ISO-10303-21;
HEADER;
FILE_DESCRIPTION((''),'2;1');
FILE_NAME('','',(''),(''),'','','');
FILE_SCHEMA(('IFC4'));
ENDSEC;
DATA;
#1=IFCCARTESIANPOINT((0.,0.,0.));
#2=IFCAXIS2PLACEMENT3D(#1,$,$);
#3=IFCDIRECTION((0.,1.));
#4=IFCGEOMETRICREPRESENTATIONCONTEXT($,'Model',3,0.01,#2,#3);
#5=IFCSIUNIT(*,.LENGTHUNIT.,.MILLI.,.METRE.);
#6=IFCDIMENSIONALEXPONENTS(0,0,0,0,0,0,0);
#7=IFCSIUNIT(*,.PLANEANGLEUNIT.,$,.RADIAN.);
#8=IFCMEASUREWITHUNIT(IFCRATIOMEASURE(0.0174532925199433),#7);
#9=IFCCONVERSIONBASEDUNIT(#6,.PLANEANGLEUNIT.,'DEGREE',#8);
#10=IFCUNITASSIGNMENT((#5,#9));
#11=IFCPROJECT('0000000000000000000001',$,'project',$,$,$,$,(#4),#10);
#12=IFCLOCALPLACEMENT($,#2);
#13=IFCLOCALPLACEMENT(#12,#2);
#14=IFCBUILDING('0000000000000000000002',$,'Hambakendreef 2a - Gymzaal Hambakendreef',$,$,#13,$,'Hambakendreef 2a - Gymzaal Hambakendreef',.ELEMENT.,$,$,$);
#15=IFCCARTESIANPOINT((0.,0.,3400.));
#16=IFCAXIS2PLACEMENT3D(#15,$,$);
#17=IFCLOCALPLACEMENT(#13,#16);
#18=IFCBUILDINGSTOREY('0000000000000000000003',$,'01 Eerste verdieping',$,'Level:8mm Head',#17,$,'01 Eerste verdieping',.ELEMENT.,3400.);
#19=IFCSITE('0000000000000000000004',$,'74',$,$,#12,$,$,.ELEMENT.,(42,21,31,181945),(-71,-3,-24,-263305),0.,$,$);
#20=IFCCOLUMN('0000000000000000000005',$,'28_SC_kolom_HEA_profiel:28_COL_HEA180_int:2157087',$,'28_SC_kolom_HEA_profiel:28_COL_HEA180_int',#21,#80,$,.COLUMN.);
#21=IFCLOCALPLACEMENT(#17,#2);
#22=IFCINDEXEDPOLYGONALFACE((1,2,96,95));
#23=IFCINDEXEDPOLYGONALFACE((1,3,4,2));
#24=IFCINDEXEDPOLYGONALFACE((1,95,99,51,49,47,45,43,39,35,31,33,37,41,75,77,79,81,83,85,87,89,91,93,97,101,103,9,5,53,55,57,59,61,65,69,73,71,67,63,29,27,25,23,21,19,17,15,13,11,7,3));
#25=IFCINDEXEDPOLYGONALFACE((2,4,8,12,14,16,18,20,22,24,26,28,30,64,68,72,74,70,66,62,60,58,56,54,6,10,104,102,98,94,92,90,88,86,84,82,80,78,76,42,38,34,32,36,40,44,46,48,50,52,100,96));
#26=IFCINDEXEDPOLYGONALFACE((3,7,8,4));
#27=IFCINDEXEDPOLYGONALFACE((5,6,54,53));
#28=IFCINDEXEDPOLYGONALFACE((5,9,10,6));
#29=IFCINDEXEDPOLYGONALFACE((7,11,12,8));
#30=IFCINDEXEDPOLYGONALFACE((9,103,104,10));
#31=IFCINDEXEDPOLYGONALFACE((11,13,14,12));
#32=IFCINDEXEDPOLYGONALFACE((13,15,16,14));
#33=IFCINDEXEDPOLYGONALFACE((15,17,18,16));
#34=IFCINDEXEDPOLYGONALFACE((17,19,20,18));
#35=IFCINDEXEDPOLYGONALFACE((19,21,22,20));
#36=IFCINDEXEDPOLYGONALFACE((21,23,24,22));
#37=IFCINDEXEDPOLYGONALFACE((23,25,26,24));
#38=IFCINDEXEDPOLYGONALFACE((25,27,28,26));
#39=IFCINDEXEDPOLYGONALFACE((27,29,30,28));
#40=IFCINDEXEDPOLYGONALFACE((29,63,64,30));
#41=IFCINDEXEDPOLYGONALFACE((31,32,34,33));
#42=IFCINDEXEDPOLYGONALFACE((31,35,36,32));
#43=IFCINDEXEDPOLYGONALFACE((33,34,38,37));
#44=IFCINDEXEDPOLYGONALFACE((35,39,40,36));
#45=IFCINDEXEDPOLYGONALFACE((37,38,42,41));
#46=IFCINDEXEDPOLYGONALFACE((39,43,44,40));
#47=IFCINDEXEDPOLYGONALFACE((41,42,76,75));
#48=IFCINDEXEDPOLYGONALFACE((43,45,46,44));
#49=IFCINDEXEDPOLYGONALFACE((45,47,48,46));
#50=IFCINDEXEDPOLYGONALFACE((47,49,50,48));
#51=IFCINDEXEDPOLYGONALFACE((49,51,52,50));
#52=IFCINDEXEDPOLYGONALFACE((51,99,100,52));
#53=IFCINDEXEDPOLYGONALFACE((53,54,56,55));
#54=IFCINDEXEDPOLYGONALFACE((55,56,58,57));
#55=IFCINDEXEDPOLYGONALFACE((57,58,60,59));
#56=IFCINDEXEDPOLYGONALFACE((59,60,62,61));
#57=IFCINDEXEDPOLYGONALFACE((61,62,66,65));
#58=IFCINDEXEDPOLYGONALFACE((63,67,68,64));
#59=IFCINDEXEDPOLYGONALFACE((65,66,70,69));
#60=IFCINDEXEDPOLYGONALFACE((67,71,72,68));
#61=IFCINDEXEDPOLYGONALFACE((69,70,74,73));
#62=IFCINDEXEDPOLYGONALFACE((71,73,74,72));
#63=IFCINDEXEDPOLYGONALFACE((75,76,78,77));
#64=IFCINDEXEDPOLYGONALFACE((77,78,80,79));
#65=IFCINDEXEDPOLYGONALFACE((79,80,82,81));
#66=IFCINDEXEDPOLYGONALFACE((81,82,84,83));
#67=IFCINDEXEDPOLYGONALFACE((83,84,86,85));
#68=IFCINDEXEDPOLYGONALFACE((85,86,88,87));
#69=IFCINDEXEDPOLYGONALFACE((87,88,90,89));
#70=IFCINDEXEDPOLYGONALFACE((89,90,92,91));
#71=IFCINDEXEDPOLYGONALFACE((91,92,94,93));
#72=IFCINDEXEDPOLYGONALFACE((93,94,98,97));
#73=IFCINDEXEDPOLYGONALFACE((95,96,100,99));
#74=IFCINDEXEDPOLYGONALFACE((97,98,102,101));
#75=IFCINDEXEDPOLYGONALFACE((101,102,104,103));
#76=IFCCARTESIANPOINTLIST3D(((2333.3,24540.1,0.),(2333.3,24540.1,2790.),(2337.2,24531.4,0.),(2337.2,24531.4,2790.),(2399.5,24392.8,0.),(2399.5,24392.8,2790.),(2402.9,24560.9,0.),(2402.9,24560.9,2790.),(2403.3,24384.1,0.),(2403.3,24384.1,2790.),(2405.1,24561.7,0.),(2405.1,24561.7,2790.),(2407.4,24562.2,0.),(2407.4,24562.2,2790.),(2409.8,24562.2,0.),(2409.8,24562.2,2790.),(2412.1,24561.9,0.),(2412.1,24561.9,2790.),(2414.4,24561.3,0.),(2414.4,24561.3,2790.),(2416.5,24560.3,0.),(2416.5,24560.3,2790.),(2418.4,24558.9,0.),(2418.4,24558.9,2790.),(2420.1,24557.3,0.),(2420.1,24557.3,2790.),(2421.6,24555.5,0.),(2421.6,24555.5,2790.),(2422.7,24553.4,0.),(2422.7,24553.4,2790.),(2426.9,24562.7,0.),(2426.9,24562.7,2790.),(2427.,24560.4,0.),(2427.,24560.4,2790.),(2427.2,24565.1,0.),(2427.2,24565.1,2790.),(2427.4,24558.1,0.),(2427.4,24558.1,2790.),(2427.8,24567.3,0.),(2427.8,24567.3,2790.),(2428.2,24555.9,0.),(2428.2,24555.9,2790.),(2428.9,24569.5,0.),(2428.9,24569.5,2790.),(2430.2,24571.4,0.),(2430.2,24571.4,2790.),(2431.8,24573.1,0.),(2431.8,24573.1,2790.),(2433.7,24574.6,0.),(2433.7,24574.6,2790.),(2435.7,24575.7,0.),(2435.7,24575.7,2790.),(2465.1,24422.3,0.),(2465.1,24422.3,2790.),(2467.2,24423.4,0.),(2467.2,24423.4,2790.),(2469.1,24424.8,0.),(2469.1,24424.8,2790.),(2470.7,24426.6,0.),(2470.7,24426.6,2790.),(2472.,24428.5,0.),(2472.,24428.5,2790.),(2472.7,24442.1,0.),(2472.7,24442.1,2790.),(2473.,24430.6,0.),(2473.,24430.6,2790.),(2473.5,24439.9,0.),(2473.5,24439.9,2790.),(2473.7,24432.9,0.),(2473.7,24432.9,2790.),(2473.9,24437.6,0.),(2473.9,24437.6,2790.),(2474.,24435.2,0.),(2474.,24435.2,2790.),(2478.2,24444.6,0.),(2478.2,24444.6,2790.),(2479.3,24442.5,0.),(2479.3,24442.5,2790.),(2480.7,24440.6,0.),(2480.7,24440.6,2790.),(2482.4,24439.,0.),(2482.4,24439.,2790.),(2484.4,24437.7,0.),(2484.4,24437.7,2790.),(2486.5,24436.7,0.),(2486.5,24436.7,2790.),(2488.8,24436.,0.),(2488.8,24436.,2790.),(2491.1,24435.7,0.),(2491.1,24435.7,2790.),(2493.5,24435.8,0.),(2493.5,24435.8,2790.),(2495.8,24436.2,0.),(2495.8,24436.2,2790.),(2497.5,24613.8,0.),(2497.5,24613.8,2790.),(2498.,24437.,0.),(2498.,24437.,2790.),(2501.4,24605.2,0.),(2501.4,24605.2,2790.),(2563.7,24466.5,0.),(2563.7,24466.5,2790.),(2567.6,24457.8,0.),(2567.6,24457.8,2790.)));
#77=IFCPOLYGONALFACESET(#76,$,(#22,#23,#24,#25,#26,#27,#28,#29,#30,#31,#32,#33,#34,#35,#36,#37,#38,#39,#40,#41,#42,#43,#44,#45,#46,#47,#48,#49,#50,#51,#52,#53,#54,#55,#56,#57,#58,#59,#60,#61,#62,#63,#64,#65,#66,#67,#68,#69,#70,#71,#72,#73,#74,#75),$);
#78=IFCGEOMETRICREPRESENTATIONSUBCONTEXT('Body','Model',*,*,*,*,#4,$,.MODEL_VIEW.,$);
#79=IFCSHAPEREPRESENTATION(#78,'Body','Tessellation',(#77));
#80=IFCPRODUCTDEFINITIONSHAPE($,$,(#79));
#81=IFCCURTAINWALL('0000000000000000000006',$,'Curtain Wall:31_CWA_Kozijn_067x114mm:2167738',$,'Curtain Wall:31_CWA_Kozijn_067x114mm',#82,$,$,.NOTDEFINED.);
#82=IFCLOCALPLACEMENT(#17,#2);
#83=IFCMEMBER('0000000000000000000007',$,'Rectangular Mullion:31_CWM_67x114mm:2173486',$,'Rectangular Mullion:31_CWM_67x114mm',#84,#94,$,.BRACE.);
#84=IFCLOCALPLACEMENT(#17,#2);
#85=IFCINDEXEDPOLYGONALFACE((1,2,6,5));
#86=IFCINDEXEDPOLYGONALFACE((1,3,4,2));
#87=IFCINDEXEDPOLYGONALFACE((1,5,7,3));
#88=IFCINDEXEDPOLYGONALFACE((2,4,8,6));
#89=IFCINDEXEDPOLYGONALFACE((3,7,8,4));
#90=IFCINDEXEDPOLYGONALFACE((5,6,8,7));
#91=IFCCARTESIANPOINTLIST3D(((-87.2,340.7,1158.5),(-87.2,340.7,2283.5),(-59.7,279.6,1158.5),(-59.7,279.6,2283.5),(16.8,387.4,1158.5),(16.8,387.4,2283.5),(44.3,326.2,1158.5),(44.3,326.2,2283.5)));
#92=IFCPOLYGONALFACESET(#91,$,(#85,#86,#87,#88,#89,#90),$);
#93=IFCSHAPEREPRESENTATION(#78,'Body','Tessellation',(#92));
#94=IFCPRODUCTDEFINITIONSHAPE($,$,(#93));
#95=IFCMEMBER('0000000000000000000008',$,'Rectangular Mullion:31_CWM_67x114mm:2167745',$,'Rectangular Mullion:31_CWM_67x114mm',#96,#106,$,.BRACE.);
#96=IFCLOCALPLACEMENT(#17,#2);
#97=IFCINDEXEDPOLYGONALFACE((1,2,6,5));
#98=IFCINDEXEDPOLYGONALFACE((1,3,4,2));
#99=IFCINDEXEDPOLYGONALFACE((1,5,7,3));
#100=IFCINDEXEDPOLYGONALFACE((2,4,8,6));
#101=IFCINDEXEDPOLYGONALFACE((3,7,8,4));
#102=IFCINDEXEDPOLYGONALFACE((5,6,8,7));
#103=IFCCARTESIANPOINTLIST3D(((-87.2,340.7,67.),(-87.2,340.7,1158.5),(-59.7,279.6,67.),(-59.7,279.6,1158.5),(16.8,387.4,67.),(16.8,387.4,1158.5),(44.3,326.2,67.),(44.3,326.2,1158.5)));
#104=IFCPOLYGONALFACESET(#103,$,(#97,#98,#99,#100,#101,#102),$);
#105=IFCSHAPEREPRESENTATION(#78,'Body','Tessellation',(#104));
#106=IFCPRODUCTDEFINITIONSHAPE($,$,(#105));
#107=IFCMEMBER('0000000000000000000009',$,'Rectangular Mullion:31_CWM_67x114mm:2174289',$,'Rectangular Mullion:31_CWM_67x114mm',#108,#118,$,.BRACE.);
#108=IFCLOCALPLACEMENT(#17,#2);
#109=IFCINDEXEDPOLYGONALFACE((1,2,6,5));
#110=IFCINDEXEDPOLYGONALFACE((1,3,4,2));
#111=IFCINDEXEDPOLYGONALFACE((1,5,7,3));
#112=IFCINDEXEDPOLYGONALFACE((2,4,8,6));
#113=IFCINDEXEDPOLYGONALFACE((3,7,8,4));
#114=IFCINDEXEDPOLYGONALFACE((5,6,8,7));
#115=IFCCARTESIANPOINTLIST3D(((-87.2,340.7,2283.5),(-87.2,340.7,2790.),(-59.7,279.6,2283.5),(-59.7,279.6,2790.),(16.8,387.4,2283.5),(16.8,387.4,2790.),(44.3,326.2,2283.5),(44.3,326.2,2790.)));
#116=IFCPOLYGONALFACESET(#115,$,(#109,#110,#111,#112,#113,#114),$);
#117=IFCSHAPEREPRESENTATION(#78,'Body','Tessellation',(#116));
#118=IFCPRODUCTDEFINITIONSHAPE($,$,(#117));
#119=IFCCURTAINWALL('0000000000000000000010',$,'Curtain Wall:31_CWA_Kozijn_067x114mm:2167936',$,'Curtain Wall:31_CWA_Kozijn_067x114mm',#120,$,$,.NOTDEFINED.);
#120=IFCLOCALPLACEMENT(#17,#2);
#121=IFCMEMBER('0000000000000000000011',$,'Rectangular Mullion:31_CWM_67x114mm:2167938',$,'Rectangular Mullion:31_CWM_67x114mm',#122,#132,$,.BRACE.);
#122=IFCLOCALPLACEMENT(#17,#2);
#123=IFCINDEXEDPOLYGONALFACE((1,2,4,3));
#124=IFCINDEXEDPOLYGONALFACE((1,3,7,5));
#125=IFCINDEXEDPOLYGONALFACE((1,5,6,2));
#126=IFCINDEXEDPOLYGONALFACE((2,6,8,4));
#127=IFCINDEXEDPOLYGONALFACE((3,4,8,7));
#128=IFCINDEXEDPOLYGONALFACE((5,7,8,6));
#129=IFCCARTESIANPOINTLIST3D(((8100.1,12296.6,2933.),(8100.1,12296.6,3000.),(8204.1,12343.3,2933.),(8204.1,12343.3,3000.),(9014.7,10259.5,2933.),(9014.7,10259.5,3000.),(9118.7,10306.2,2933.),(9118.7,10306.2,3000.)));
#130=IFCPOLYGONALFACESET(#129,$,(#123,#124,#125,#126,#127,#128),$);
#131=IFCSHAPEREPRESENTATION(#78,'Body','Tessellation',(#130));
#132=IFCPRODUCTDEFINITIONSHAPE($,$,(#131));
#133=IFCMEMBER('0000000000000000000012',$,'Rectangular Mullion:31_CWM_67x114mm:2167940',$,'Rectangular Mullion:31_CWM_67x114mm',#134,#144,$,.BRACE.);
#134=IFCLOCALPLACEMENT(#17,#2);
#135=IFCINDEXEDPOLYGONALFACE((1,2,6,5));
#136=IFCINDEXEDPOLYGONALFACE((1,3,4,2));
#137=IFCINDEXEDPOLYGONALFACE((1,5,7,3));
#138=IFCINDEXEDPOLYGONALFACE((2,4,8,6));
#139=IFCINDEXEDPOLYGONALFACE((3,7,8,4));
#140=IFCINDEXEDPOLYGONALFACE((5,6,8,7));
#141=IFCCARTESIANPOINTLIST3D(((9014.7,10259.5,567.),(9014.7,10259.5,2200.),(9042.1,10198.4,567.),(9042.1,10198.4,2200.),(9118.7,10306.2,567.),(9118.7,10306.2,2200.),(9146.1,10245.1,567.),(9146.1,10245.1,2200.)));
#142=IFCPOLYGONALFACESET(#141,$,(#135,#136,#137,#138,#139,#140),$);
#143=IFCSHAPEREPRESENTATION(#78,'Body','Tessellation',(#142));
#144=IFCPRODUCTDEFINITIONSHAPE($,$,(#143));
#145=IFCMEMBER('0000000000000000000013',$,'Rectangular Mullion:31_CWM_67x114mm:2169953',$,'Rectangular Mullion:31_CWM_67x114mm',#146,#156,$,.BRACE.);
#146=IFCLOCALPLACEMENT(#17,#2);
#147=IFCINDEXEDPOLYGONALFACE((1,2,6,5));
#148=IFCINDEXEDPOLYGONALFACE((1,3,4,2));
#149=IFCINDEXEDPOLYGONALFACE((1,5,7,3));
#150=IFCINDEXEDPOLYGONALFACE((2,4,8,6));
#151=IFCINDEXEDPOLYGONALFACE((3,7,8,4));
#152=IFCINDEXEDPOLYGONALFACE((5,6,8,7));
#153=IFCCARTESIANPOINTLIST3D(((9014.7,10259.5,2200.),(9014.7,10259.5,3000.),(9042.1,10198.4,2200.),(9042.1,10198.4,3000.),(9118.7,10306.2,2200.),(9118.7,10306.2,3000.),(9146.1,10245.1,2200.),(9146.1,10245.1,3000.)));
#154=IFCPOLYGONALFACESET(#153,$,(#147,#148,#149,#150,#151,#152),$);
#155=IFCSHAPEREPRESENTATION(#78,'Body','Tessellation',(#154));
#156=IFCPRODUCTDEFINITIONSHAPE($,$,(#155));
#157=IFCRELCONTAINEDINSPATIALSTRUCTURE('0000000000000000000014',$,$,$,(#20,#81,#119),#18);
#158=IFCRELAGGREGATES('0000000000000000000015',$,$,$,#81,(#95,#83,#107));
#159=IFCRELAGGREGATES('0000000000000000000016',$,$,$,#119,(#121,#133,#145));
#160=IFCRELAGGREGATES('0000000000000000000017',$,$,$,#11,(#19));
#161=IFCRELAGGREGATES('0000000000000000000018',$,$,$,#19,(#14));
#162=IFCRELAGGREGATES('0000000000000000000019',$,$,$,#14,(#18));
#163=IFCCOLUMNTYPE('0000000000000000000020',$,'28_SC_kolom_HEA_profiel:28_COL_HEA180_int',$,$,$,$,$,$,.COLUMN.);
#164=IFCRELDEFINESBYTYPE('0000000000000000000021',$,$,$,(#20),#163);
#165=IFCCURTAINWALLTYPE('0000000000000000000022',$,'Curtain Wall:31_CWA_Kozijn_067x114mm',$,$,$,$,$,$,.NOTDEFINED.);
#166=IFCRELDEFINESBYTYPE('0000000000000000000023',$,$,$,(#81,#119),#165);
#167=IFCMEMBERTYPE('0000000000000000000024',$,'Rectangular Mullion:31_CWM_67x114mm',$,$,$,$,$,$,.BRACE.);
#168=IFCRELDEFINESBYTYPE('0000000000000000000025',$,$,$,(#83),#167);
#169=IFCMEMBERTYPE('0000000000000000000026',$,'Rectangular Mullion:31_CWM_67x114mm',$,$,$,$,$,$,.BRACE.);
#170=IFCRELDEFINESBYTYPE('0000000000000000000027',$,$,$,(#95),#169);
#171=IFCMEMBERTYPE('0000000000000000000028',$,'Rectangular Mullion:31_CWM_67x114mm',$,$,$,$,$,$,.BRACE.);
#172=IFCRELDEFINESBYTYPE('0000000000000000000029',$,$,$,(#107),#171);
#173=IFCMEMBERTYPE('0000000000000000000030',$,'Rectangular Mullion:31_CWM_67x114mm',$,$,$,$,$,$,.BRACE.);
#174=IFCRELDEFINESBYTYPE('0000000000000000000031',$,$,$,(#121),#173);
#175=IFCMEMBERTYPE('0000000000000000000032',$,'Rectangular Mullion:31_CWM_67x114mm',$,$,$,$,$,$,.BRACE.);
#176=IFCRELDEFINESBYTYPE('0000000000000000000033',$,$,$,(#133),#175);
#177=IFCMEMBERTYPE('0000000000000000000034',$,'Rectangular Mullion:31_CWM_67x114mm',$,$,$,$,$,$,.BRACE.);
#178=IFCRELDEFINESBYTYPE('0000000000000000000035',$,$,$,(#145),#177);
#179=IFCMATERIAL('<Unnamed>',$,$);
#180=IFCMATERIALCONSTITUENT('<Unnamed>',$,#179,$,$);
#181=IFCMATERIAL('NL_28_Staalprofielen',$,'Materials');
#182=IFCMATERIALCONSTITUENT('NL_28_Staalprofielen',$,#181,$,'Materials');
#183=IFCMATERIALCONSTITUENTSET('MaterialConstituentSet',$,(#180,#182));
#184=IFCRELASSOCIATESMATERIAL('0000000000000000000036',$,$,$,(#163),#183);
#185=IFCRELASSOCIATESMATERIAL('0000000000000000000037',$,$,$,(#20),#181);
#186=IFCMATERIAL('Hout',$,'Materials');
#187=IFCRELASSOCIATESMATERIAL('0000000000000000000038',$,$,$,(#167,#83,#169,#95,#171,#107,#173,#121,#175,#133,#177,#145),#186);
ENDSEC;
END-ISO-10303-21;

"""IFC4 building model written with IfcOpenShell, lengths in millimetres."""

from ifc_helpers import new_model, entity, si_unit, converted_unit, direction, frame, origin, place, context, subcontext, project, spatial, indexed_curve, outline, extrude, source, transform, mapped, material, constituent, constituent_set, type_object, type_shapes, element, aggregate, save


model = new_model("IFC4")

# Units and contexts
model_context = context("Model", 3, precision=0.01, world=origin(), true_north=direction((0.0, 1.0)))
body_context = subcontext(model_context, "Body", "Model", "MODEL_VIEW")
ifc_project = project(units=[si_unit("LENGTHUNIT", "METRE", prefix="MILLI"), converted_unit("PLANEANGLEUNIT", "DEGREE", entity("IfcRatioMeasure", 0.0174532925199433), si_unit("PLANEANGLEUNIT", "RADIAN"), dimensions=[0, 0, 0, 0, 0, 0, 0])], contexts=[model_context])

# Site, building, storey
site_placement = place(None, origin())
site = spatial("IfcSite", under=ifc_project, at=site_placement, Name="74", CompositionType="ELEMENT", RefLatitude=(42, 21, 31, 181945), RefLongitude=(-71, -3, -24, -263305), RefElevation=0.0)
building_placement = place(site_placement, origin())
building = spatial("IfcBuilding", under=site, at=building_placement, Name="Hambakendreef 2a - Gymzaal Hambakendreef", LongName="Hambakendreef 2a - Gymzaal Hambakendreef", CompositionType="ELEMENT")
storey_placement = place(building_placement, frame((0.0, 0.0, 3400.0)))
storey = spatial("IfcBuildingStorey", under=building, at=storey_placement, Name="01 Eerste verdieping", ObjectType="Level:8mm Head", LongName="01 Eerste verdieping", CompositionType="ELEMENT", Elevation=3400.0)

# Column
ifc_material_1 = material(Name="NL_28_Staalprofielen", Category="Materials")
ifc_material_2 = material(Name="<Unnamed>")
ifc_constituent_1 = constituent(ifc_material_2, Name="<Unnamed>")
ifc_constituent_2 = constituent(ifc_material_1, Name="NL_28_Staalprofielen", Category="Materials")
ifc_constituent_set_1 = constituent_set(constituents=[ifc_constituent_1, ifc_constituent_2], Name="MaterialConstituentSet")
column_type_1 = type_object("IfcColumnType", Name="28_SC_kolom_HEA_profiel:28_COL_HEA180_int", PredefinedType="COLUMN", material=ifc_constituent_set_1)
shared_shape_1 = source(origin(), body_context, "Body", "SweptSolid", [
    extrude(outline(indexed_curve([(-85.5, -90.0), (-76.0, -90.0), (-76.0, -18.0), (-75.8, -15.7), (-75.3, -13.4), (-74.4, -11.2), (-73.1, -9.2), (-71.6, -7.4), (-69.8, -5.9), (-67.8, -4.6), (-65.6, -3.7), (-63.3, -3.2), (-61.0, -3.0), (61.0, -3.0), (63.3, -3.2), (65.6, -3.7), (67.8, -4.6), (69.8, -5.9), (71.6, -7.4), (73.1, -9.2), (74.4, -11.2), (75.3, -13.4), (75.8, -15.7), (76.0, -18.0), (76.0, -90.0), (85.5, -90.0), (85.5, 90.0), (76.0, 90.0), (76.0, 18.0), (75.8, 15.7), (75.3, 13.4), (74.4, 11.2), (73.1, 9.2), (71.6, 7.4), (69.8, 5.9), (67.8, 4.6), (65.6, 3.7), (63.3, 3.2), (61.0, 3.0), (-61.0, 3.0), (-63.3, 3.2), (-65.6, 3.7), (-67.8, 4.6), (-69.8, 5.9), (-71.6, 7.4), (-73.1, 9.2), (-74.4, 11.2), (-75.3, 13.4), (-75.8, 15.7), (-76.0, 18.0), (-76.0, 90.0), (-85.5, 90.0), (-85.5, -90.0)], self_intersect=False)), frame((2450.4, 24499.0, 3400.0), z_axis=(0.0, 0.0, 1.0), x_axis=(-0.40959, 0.91227, 0.0)), (0.0, 0.0, 1.0), 2790.0),
])
type_shapes(column_type_1, [shared_shape_1])
column_1_placement = place(storey_placement, frame((0.0, 0.0, -3400.0)))
element("IfcColumn", 1, at=column_1_placement, inside=storey, type_object=column_type_1, material=ifc_material_1, Name="28_SC_kolom_HEA_profiel:28_COL_HEA180_int:2157087", ObjectType="28_SC_kolom_HEA_profiel:28_COL_HEA180_int", PredefinedType="COLUMN", context=body_context, shape_type="MappedRepresentation", body=[
    mapped(shared_shape_1, transform((0.0, 0.0, 0.0), scale=1.0)),
])

# Curtain walls, members
curtain_wall_type = type_object("IfcCurtainWallType", Name="Curtain Wall:31_CWA_Kozijn_067x114mm", PredefinedType="NOTDEFINED")
curtain_wall_1_placement = place(storey_placement, frame((0.0, 0.0, -3400.0)))
curtain_wall_1 = element("IfcCurtainWall", 2, at=curtain_wall_1_placement, inside=storey, type_object=curtain_wall_type, Name="Curtain Wall:31_CWA_Kozijn_067x114mm:2167738", ObjectType="Curtain Wall:31_CWA_Kozijn_067x114mm", PredefinedType="NOTDEFINED")
ifc_material_3 = material(Name="Hout", Category="Materials")
member_type_1 = type_object("IfcMemberType", Name="Rectangular Mullion:31_CWM_67x114mm", PredefinedType="BRACE", material=ifc_material_3)
shared_shape_2 = source(origin(), body_context, "Body", "SweptSolid", [
    extrude(outline(indexed_curve([(-57.0, -33.5), (57.0, -33.5), (57.0, 33.5), (-57.0, 33.5), (-57.0, -33.5)], self_intersect=False)), frame((-33.5, 0.0, -1125.0), z_axis=(0.0, 0.0, 1.0), x_axis=(0.0, -1.0, 0.0)), (0.0, 0.0, 1.0), 1125.0),
])
type_shapes(member_type_1, [shared_shape_2])
member_1_placement = place(storey_placement, frame((-7.7, 302.9, 1158.5), z_axis=(0.0, 0.0, -1.0), x_axis=(0.40959, -0.91227, 0.0)))
member_1 = element("IfcMember", 3, at=member_1_placement, type_object=member_type_1, material=ifc_material_3, Name="Rectangular Mullion:31_CWM_67x114mm:2173486", ObjectType="Rectangular Mullion:31_CWM_67x114mm", PredefinedType="BRACE", context=body_context, shape_type="MappedRepresentation", body=[
    mapped(shared_shape_2, transform((0.0, 0.0, 0.0), scale=1.0)),
])
member_type_2 = type_object("IfcMemberType", Name="Rectangular Mullion:31_CWM_67x114mm", PredefinedType="BRACE", material=ifc_material_3)
shared_shape_3 = source(origin(), body_context, "Body", "SweptSolid", [
    extrude(outline(indexed_curve([(-57.0, -33.5), (57.0, -33.5), (57.0, 33.5), (-57.0, 33.5), (-57.0, -33.5)], self_intersect=False)), frame((-33.5, 0.0, -1091.5), z_axis=(0.0, 0.0, 1.0), x_axis=(0.0, -1.0, 0.0)), (0.0, 0.0, 1.0), 1091.5),
])
type_shapes(member_type_2, [shared_shape_3])
member_2_placement = place(storey_placement, frame((-7.7, 302.9, 67.0), z_axis=(0.0, 0.0, -1.0), x_axis=(0.40959, -0.91227, 0.0)))
member_2 = element("IfcMember", 4, at=member_2_placement, type_object=member_type_2, material=ifc_material_3, Name="Rectangular Mullion:31_CWM_67x114mm:2167745", ObjectType="Rectangular Mullion:31_CWM_67x114mm", PredefinedType="BRACE", context=body_context, shape_type="MappedRepresentation", body=[
    mapped(shared_shape_3, transform((0.0, 0.0, 0.0), scale=1.0)),
])
member_type_3 = type_object("IfcMemberType", Name="Rectangular Mullion:31_CWM_67x114mm", PredefinedType="BRACE", material=ifc_material_3)
shared_shape_4 = source(origin(), body_context, "Body", "SweptSolid", [
    extrude(outline(indexed_curve([(-57.0, -33.5), (57.0, -33.5), (57.0, 33.5), (-57.0, 33.5), (-57.0, -33.5)], self_intersect=False)), frame((-33.5, 0.0, -506.5), z_axis=(0.0, 0.0, 1.0), x_axis=(0.0, -1.0, 0.0)), (0.0, 0.0, 1.0), 506.5),
])
type_shapes(member_type_3, [shared_shape_4])
member_3_placement = place(storey_placement, frame((-7.7, 302.9, 2283.5), z_axis=(0.0, 0.0, -1.0), x_axis=(0.40959, -0.91227, 0.0)))
member_3 = element("IfcMember", 5, at=member_3_placement, type_object=member_type_3, material=ifc_material_3, Name="Rectangular Mullion:31_CWM_67x114mm:2174289", ObjectType="Rectangular Mullion:31_CWM_67x114mm", PredefinedType="BRACE", context=body_context, shape_type="MappedRepresentation", body=[
    mapped(shared_shape_4, transform((0.0, 0.0, 0.0), scale=1.0)),
])
aggregate(curtain_wall_1, [member_2, member_1, member_3])
curtain_wall_2_placement = place(storey_placement, frame((0.0, 0.0, -3400.0)))
curtain_wall_2 = element("IfcCurtainWall", 6, at=curtain_wall_2_placement, inside=storey, type_object=curtain_wall_type, Name="Curtain Wall:31_CWA_Kozijn_067x114mm:2167936", ObjectType="Curtain Wall:31_CWA_Kozijn_067x114mm", PredefinedType="NOTDEFINED")
member_type_4 = type_object("IfcMemberType", Name="Rectangular Mullion:31_CWM_67x114mm", PredefinedType="BRACE", material=ifc_material_3)
shared_shape_5 = source(origin(), body_context, "Body", "SweptSolid", [
    extrude(outline(indexed_curve([(-57.0, -33.5), (57.0, -33.5), (57.0, 33.5), (-57.0, 33.5), (-57.0, -33.5)], self_intersect=False)), frame((-33.5, 0.0, -2233.0), z_axis=(0.0, 0.0, 1.0), x_axis=(0.0, -1.0, 0.0)), (0.0, 0.0, 1.0), 2233.0),
])
type_shapes(member_type_4, [shared_shape_5])
member_4_placement = place(storey_placement, frame((9066.7, 10282.9, 3000.0), z_axis=(0.40959, -0.91227, 0.0), x_axis=(0.0, 0.0, 1.0)))
member_4 = element("IfcMember", 7, at=member_4_placement, type_object=member_type_4, material=ifc_material_3, Name="Rectangular Mullion:31_CWM_67x114mm:2167938", ObjectType="Rectangular Mullion:31_CWM_67x114mm", PredefinedType="BRACE", context=body_context, shape_type="MappedRepresentation", body=[
    mapped(shared_shape_5, transform((0.0, 0.0, 0.0), scale=1.0)),
])
member_type_5 = type_object("IfcMemberType", Name="Rectangular Mullion:31_CWM_67x114mm", PredefinedType="BRACE", material=ifc_material_3)
shared_shape_6 = source(origin(), body_context, "Body", "SweptSolid", [
    extrude(outline(indexed_curve([(-57.0, -33.5), (57.0, -33.5), (57.0, 33.5), (-57.0, 33.5), (-57.0, -33.5)], self_intersect=False)), frame((-33.5, 0.0, -1633.0), z_axis=(0.0, 0.0, 1.0), x_axis=(0.0, -1.0, 0.0)), (0.0, 0.0, 1.0), 1633.0),
])
type_shapes(member_type_5, [shared_shape_6])
member_5_placement = place(storey_placement, frame((9094.1, 10221.7, 567.0), z_axis=(0.0, 0.0, -1.0), x_axis=(0.40959, -0.91227, 0.0)))
member_5 = element("IfcMember", 8, at=member_5_placement, type_object=member_type_5, material=ifc_material_3, Name="Rectangular Mullion:31_CWM_67x114mm:2167940", ObjectType="Rectangular Mullion:31_CWM_67x114mm", PredefinedType="BRACE", context=body_context, shape_type="MappedRepresentation", body=[
    mapped(shared_shape_6, transform((0.0, 0.0, 0.0), scale=1.0)),
])
member_type_6 = type_object("IfcMemberType", Name="Rectangular Mullion:31_CWM_67x114mm", PredefinedType="BRACE", material=ifc_material_3)
shared_shape_7 = source(origin(), body_context, "Body", "SweptSolid", [
    extrude(outline(indexed_curve([(-57.0, -33.5), (57.0, -33.5), (57.0, 33.5), (-57.0, 33.5), (-57.0, -33.5)], self_intersect=False)), frame((-33.5, 0.0, -800.0), z_axis=(0.0, 0.0, 1.0), x_axis=(0.0, -1.0, 0.0)), (0.0, 0.0, 1.0), 800.0),
])
type_shapes(member_type_6, [shared_shape_7])
member_6_placement = place(storey_placement, frame((9094.1, 10221.7, 2200.0), z_axis=(0.0, 0.0, -1.0), x_axis=(0.40959, -0.91227, 0.0)))
member_6 = element("IfcMember", 9, at=member_6_placement, type_object=member_type_6, material=ifc_material_3, Name="Rectangular Mullion:31_CWM_67x114mm:2169953", ObjectType="Rectangular Mullion:31_CWM_67x114mm", PredefinedType="BRACE", context=body_context, shape_type="MappedRepresentation", body=[
    mapped(shared_shape_7, transform((0.0, 0.0, 0.0), scale=1.0)),
])
aggregate(curtain_wall_2, [member_4, member_5, member_6])

save(model, "model.ifc")
